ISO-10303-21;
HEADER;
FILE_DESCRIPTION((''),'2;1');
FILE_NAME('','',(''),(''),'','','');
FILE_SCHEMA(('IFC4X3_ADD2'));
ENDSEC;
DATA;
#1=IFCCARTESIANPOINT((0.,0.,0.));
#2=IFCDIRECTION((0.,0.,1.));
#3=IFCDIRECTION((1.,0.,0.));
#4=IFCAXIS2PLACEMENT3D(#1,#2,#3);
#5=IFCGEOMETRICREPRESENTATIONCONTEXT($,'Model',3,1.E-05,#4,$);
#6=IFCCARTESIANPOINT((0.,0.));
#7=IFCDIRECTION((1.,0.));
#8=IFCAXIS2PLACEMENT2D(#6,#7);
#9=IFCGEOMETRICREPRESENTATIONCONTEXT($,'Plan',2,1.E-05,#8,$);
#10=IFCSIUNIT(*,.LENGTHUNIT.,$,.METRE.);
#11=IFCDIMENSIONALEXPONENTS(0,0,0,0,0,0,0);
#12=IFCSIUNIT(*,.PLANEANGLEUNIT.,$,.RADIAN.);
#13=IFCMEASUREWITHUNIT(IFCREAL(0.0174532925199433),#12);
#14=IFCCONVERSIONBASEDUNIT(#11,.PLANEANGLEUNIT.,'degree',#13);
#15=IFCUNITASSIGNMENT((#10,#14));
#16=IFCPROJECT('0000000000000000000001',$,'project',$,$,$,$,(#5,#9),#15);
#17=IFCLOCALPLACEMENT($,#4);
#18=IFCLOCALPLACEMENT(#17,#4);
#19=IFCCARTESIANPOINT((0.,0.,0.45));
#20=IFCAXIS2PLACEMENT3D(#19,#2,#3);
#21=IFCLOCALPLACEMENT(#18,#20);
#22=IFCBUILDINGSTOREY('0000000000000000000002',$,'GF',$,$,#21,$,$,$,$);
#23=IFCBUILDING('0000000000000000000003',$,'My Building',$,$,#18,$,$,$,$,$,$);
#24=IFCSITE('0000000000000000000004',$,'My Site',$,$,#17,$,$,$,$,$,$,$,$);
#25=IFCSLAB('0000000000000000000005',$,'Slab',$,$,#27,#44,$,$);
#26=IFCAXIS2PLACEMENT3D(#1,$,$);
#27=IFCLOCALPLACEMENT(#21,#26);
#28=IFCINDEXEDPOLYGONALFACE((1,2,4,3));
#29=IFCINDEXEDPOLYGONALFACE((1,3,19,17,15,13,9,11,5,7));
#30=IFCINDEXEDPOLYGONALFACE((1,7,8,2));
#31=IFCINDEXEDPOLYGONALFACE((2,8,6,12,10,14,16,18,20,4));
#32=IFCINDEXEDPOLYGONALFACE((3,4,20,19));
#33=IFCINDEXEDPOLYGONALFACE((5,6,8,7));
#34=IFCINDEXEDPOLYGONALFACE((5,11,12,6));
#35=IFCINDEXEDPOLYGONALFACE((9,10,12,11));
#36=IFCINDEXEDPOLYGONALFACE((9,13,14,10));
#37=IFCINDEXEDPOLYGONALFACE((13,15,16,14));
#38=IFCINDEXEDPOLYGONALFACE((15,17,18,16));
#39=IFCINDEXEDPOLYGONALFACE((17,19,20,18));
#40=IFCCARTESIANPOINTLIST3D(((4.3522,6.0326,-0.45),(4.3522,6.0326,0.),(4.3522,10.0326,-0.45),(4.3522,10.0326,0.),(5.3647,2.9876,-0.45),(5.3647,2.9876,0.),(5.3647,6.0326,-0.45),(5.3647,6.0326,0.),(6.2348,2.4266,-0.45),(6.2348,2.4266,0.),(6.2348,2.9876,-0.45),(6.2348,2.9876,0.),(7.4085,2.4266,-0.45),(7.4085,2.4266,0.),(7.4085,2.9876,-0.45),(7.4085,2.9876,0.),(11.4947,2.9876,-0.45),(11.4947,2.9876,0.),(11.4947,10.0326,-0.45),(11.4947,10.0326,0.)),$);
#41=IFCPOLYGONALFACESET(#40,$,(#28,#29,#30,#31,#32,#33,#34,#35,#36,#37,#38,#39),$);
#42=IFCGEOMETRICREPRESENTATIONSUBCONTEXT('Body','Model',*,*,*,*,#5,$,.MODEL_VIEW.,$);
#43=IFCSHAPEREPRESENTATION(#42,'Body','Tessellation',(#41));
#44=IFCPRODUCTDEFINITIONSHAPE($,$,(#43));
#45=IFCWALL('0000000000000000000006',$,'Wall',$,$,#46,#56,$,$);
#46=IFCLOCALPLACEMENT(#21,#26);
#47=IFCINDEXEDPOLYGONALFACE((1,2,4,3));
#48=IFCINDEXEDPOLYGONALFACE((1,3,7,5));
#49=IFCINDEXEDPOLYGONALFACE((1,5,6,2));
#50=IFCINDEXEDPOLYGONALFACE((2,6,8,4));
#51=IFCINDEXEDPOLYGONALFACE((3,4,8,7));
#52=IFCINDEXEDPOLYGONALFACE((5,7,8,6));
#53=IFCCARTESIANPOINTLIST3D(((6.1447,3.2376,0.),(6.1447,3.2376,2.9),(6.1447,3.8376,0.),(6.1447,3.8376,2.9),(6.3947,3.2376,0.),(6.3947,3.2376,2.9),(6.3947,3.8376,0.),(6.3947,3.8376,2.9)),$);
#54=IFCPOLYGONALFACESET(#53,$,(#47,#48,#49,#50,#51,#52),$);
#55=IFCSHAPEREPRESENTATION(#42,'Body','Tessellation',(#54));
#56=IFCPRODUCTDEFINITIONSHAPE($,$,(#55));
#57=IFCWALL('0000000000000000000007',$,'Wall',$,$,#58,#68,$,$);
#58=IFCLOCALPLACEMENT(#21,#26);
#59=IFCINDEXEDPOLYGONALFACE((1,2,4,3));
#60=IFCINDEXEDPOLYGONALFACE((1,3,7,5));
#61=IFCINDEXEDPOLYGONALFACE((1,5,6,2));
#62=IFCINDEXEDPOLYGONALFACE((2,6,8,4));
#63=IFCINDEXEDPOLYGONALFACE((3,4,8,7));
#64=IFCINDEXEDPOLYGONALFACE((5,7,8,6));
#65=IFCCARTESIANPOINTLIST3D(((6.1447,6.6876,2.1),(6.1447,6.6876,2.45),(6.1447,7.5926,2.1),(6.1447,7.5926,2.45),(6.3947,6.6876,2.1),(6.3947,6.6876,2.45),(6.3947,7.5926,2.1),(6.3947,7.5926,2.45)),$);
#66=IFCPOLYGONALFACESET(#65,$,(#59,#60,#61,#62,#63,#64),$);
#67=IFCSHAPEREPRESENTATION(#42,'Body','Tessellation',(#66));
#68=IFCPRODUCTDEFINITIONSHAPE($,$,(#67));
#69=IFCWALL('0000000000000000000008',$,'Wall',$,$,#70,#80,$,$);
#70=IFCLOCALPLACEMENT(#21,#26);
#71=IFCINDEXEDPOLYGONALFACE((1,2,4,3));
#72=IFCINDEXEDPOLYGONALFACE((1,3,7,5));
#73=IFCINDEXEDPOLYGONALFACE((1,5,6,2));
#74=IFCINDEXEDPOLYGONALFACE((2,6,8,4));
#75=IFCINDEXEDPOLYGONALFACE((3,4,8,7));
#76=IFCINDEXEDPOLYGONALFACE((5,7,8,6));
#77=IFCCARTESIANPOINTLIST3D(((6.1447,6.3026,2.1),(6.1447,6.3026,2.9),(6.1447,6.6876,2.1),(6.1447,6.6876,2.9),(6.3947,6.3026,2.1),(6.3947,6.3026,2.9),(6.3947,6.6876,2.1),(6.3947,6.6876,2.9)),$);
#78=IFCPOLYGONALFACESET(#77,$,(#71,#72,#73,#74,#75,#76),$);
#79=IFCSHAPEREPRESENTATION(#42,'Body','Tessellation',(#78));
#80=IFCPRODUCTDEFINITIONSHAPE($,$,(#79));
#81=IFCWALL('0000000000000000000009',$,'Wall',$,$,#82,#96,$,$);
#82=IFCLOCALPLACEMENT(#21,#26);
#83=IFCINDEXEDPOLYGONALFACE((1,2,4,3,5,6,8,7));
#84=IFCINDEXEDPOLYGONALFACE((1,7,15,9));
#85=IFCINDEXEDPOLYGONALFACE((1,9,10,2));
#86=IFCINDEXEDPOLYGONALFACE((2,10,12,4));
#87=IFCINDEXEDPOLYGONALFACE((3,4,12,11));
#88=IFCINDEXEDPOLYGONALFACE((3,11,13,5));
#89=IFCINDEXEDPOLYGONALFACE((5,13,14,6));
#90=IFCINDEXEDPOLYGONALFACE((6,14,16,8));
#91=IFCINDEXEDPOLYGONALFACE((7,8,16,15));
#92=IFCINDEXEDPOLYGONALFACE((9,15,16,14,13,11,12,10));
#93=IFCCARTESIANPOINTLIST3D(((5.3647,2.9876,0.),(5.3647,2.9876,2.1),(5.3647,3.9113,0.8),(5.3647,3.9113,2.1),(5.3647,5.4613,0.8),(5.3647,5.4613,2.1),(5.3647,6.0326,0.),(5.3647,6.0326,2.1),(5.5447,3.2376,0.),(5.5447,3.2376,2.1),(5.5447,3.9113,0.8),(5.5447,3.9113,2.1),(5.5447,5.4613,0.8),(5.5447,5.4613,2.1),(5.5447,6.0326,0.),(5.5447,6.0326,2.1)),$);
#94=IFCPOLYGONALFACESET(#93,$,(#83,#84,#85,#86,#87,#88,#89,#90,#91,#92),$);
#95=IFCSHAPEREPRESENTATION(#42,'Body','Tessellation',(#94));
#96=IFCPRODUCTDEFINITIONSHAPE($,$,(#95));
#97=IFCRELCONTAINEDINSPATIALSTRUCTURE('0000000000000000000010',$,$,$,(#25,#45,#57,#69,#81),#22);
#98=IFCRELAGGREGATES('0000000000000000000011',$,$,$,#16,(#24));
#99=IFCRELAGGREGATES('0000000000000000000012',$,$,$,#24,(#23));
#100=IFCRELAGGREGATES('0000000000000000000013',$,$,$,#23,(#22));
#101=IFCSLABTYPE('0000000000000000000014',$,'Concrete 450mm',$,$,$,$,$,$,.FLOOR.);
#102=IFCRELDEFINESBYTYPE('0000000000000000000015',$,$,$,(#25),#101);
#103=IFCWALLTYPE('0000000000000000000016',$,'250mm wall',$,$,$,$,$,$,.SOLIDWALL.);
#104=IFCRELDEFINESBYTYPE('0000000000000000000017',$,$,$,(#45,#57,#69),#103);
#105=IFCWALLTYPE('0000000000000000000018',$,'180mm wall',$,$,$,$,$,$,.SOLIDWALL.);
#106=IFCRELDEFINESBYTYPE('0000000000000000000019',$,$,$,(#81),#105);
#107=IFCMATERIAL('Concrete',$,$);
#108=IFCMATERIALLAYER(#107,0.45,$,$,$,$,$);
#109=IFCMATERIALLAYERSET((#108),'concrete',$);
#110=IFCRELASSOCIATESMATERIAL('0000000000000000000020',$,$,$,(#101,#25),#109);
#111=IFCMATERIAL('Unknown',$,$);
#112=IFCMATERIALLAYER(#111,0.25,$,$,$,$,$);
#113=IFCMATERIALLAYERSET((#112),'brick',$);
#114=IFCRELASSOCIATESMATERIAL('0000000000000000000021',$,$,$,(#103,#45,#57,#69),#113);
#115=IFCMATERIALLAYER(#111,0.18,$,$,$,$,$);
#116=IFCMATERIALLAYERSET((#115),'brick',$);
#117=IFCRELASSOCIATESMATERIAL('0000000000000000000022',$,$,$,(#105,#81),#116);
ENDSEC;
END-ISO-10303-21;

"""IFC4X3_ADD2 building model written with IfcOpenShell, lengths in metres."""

from ifc_helpers import new_model, entity, si_unit, converted_unit, frame, origin_with_axes, origin_2d_with_axis, place, context, subcontext, project, spatial, line, indexed_curve, outline, extrude, source, transform, mapped, material, layer, layer_set, layer_usage, type_object, element, save


model = new_model("IFC4X3_ADD2")

# Units and contexts
model_context = context("Model", 3, precision=1e-05, world=origin_with_axes())
plan_context = context("Plan", 2, precision=1e-05, world=origin_2d_with_axis())
body_context_1 = subcontext(model_context, "Body", "Model", "MODEL_VIEW")
ifc_project = project(units=[si_unit("LENGTHUNIT", "METRE"), converted_unit("PLANEANGLEUNIT", "degree", entity("IfcReal", 0.0174532925199433), si_unit("PLANEANGLEUNIT", "RADIAN"), dimensions=[0, 0, 0, 0, 0, 0, 0])], contexts=[model_context, plan_context])

# Site, building, storey
site_placement = place(None, origin_with_axes())
site = spatial("IfcSite", under=ifc_project, at=site_placement, Name="My Site")
building_placement = place(site_placement, origin_with_axes())
building = spatial("IfcBuilding", under=site, at=building_placement, Name="My Building")
storey_placement = place(building_placement, frame((0.0, 0.0, 0.45), z_axis=(0.0, 0.0, 1.0), x_axis=(1.0, 0.0, 0.0)))
storey = spatial("IfcBuildingStorey", under=building, at=storey_placement, Name="GF")

# Slab
ifc_material_1 = material(Name="Concrete")
ifc_layer_1 = layer(ifc_material_1, 0.45)
ifc_layer_set_1 = layer_set([ifc_layer_1], Name="concrete")
ifc_layer_usage_1 = layer_usage(ifc_layer_set_1, "AXIS3", "POSITIVE", -0.45)
slab_type_1 = type_object("IfcSlabType", Name="Concrete 450mm", PredefinedType="FLOOR", material=ifc_layer_set_1)
slab_1_placement = place(storey_placement, frame((4.3522, 2.9876, 0.0), z_axis=(0.0, 0.0, 1.0), x_axis=(1.0, 0.0, 0.0)))
element("IfcSlab", 1, at=slab_1_placement, inside=storey, type_object=slab_type_1, material=ifc_layer_usage_1, Name="Slab", context=body_context_1, shape_type="SweptSolid", body=[
    extrude(outline(indexed_curve([(1.0125, 3.045), (1.0125, 0.0), (1.8826, 0.0), (1.8826, -0.561), (3.0563, -0.561), (3.0563, 0.0), (7.1425, 0.0), (7.1425, 7.045), (0.0, 7.045), (0.0, 3.045), (1.0125, 3.045)])), frame((0.0, 0.0, -0.45), z_axis=(0.0, 0.0, 1.0), x_axis=(1.0, 0.0, 0.0)), (0.0, 0.0, 1.0), 0.45),
])

# Walls
ifc_material_2 = material(Name="Unknown")
ifc_layer_2 = layer(ifc_material_2, 0.25)
ifc_layer_set_2 = layer_set([ifc_layer_2], Name="brick")
ifc_layer_usage_2 = layer_usage(ifc_layer_set_2, "AXIS2", "POSITIVE", 0.0)
wall_type_1 = type_object("IfcWallType", Name="250mm wall", PredefinedType="SOLIDWALL", material=ifc_layer_set_2)
wall_1_placement = place(storey_placement, frame((6.3947, 3.2376, 0.0), z_axis=(0.0, 0.0, 1.0), x_axis=(0.0, 1.0, 0.0)))
element("IfcWall", 2, at=wall_1_placement, inside=storey, type_object=wall_type_1, material=ifc_layer_usage_2, Name="Wall", context=body_context_1, shape_type="SweptSolid", body=[
    extrude(outline(indexed_curve([(0.0, 0.0), (0.0, 0.25), (0.6, 0.25), (0.6, 0.0), (0.0, 0.0)], self_intersect=False)), origin_with_axes(), (0.0, 0.0, 1.0), 2.9),
])
ifc_layer_usage_3 = layer_usage(ifc_layer_set_2, "AXIS2", "POSITIVE", 0.0)
wall_2_placement = place(storey_placement, frame((6.3947, 6.6876, 2.1), z_axis=(0.0, 0.0, 1.0), x_axis=(0.0, 1.0, 0.0)))
element("IfcWall", 3, at=wall_2_placement, inside=storey, type_object=wall_type_1, material=ifc_layer_usage_3, Name="Wall", context=body_context_1, shape_type="SweptSolid", body=[
    extrude(outline(indexed_curve([(0.0, 0.0), (0.0, 0.25), (0.905, 0.25), (0.905, 0.0)], segments=[line(1, 2, 3, 4, 1)])), origin_with_axes(), (0.0, 0.0, 1.0), 0.35),
])
ifc_layer_usage_4 = layer_usage(ifc_layer_set_2, "AXIS2", "POSITIVE", 0.0)
wall_3_placement = place(storey_placement, frame((6.3947, 6.3026, 2.1), z_axis=(0.0, 0.0, 1.0), x_axis=(0.0, 1.0, 0.0)))
element("IfcWall", 4, at=wall_3_placement, inside=storey, type_object=wall_type_1, material=ifc_layer_usage_4, Name="Wall", context=body_context_1, shape_type="SweptSolid", body=[
    extrude(outline(indexed_curve([(0.0, 0.0), (0.0, 0.25), (0.385, 0.25), (0.385, 0.0)], segments=[line(1, 2, 3, 4, 1)])), origin_with_axes(), (0.0, 0.0, 1.0), 0.8),
])

# Wall, opening
ifc_layer_3 = layer(ifc_material_2, 0.18)
ifc_layer_set_3 = layer_set([ifc_layer_3], Name="brick")
ifc_layer_usage_5 = layer_usage(ifc_layer_set_3, "AXIS2", "POSITIVE", 0.0)
wall_type_2 = type_object("IfcWallType", Name="180mm wall", PredefinedType="SOLIDWALL", material=ifc_layer_set_3)
wall_4_placement = place(storey_placement, frame((5.5447, 2.9876, 0.0), z_axis=(0.0, 0.0, 1.0), x_axis=(0.0, 1.0, 0.0)))
wall_4 = element("IfcWall", 5, at=wall_4_placement, inside=storey, type_object=wall_type_2, material=ifc_layer_usage_5, Name="Wall", context=body_context_1, shape_type="SweptSolid", body=[
    extrude(outline(indexed_curve([(0.25, 0.0), (0.0, 0.18), (3.045, 0.18), (3.045, 0.0)], segments=[line(1, 2, 3, 4, 1)])), origin_with_axes(), (0.0, 0.0, 1.0), 2.1),
])
shared_shape_1 = source(origin_with_axes(), body_context_1, "Body", "SweptSolid", [
    extrude(outline(indexed_curve([(0.0, 0.0), (1.55, 0.0), (1.55, 1.3), (0.0, 1.3)], segments=[line(1, 2, 3, 4, 1)])), frame((-0.775, -0.6, 0.0), z_axis=(0.0, -1.0, 0.0), x_axis=(1.0, 0.0, 0.0)), (0.0, 0.0, -1.0), 1.2),
])
opening_1_placement = place(wall_4_placement, frame((1.6987, 0.0, 0.8), z_axis=(0.0, 0.0, 1.0), x_axis=(1.0, 0.0, 0.0)))
element("IfcOpeningElement", 6, at=opening_1_placement, cuts=wall_4, PredefinedType="OPENING", context=body_context_1, shape_type="MappedRepresentation", body=[
    mapped(shared_shape_1, transform((0.0, 0.0, 0.0), x_axis=(1.0, 0.0, 0.0), y_axis=(0.0, 1.0, 0.0), z_axis=(0.0, 0.0, 1.0), scale=1.0)),
])

save(model, "model.ifc")
